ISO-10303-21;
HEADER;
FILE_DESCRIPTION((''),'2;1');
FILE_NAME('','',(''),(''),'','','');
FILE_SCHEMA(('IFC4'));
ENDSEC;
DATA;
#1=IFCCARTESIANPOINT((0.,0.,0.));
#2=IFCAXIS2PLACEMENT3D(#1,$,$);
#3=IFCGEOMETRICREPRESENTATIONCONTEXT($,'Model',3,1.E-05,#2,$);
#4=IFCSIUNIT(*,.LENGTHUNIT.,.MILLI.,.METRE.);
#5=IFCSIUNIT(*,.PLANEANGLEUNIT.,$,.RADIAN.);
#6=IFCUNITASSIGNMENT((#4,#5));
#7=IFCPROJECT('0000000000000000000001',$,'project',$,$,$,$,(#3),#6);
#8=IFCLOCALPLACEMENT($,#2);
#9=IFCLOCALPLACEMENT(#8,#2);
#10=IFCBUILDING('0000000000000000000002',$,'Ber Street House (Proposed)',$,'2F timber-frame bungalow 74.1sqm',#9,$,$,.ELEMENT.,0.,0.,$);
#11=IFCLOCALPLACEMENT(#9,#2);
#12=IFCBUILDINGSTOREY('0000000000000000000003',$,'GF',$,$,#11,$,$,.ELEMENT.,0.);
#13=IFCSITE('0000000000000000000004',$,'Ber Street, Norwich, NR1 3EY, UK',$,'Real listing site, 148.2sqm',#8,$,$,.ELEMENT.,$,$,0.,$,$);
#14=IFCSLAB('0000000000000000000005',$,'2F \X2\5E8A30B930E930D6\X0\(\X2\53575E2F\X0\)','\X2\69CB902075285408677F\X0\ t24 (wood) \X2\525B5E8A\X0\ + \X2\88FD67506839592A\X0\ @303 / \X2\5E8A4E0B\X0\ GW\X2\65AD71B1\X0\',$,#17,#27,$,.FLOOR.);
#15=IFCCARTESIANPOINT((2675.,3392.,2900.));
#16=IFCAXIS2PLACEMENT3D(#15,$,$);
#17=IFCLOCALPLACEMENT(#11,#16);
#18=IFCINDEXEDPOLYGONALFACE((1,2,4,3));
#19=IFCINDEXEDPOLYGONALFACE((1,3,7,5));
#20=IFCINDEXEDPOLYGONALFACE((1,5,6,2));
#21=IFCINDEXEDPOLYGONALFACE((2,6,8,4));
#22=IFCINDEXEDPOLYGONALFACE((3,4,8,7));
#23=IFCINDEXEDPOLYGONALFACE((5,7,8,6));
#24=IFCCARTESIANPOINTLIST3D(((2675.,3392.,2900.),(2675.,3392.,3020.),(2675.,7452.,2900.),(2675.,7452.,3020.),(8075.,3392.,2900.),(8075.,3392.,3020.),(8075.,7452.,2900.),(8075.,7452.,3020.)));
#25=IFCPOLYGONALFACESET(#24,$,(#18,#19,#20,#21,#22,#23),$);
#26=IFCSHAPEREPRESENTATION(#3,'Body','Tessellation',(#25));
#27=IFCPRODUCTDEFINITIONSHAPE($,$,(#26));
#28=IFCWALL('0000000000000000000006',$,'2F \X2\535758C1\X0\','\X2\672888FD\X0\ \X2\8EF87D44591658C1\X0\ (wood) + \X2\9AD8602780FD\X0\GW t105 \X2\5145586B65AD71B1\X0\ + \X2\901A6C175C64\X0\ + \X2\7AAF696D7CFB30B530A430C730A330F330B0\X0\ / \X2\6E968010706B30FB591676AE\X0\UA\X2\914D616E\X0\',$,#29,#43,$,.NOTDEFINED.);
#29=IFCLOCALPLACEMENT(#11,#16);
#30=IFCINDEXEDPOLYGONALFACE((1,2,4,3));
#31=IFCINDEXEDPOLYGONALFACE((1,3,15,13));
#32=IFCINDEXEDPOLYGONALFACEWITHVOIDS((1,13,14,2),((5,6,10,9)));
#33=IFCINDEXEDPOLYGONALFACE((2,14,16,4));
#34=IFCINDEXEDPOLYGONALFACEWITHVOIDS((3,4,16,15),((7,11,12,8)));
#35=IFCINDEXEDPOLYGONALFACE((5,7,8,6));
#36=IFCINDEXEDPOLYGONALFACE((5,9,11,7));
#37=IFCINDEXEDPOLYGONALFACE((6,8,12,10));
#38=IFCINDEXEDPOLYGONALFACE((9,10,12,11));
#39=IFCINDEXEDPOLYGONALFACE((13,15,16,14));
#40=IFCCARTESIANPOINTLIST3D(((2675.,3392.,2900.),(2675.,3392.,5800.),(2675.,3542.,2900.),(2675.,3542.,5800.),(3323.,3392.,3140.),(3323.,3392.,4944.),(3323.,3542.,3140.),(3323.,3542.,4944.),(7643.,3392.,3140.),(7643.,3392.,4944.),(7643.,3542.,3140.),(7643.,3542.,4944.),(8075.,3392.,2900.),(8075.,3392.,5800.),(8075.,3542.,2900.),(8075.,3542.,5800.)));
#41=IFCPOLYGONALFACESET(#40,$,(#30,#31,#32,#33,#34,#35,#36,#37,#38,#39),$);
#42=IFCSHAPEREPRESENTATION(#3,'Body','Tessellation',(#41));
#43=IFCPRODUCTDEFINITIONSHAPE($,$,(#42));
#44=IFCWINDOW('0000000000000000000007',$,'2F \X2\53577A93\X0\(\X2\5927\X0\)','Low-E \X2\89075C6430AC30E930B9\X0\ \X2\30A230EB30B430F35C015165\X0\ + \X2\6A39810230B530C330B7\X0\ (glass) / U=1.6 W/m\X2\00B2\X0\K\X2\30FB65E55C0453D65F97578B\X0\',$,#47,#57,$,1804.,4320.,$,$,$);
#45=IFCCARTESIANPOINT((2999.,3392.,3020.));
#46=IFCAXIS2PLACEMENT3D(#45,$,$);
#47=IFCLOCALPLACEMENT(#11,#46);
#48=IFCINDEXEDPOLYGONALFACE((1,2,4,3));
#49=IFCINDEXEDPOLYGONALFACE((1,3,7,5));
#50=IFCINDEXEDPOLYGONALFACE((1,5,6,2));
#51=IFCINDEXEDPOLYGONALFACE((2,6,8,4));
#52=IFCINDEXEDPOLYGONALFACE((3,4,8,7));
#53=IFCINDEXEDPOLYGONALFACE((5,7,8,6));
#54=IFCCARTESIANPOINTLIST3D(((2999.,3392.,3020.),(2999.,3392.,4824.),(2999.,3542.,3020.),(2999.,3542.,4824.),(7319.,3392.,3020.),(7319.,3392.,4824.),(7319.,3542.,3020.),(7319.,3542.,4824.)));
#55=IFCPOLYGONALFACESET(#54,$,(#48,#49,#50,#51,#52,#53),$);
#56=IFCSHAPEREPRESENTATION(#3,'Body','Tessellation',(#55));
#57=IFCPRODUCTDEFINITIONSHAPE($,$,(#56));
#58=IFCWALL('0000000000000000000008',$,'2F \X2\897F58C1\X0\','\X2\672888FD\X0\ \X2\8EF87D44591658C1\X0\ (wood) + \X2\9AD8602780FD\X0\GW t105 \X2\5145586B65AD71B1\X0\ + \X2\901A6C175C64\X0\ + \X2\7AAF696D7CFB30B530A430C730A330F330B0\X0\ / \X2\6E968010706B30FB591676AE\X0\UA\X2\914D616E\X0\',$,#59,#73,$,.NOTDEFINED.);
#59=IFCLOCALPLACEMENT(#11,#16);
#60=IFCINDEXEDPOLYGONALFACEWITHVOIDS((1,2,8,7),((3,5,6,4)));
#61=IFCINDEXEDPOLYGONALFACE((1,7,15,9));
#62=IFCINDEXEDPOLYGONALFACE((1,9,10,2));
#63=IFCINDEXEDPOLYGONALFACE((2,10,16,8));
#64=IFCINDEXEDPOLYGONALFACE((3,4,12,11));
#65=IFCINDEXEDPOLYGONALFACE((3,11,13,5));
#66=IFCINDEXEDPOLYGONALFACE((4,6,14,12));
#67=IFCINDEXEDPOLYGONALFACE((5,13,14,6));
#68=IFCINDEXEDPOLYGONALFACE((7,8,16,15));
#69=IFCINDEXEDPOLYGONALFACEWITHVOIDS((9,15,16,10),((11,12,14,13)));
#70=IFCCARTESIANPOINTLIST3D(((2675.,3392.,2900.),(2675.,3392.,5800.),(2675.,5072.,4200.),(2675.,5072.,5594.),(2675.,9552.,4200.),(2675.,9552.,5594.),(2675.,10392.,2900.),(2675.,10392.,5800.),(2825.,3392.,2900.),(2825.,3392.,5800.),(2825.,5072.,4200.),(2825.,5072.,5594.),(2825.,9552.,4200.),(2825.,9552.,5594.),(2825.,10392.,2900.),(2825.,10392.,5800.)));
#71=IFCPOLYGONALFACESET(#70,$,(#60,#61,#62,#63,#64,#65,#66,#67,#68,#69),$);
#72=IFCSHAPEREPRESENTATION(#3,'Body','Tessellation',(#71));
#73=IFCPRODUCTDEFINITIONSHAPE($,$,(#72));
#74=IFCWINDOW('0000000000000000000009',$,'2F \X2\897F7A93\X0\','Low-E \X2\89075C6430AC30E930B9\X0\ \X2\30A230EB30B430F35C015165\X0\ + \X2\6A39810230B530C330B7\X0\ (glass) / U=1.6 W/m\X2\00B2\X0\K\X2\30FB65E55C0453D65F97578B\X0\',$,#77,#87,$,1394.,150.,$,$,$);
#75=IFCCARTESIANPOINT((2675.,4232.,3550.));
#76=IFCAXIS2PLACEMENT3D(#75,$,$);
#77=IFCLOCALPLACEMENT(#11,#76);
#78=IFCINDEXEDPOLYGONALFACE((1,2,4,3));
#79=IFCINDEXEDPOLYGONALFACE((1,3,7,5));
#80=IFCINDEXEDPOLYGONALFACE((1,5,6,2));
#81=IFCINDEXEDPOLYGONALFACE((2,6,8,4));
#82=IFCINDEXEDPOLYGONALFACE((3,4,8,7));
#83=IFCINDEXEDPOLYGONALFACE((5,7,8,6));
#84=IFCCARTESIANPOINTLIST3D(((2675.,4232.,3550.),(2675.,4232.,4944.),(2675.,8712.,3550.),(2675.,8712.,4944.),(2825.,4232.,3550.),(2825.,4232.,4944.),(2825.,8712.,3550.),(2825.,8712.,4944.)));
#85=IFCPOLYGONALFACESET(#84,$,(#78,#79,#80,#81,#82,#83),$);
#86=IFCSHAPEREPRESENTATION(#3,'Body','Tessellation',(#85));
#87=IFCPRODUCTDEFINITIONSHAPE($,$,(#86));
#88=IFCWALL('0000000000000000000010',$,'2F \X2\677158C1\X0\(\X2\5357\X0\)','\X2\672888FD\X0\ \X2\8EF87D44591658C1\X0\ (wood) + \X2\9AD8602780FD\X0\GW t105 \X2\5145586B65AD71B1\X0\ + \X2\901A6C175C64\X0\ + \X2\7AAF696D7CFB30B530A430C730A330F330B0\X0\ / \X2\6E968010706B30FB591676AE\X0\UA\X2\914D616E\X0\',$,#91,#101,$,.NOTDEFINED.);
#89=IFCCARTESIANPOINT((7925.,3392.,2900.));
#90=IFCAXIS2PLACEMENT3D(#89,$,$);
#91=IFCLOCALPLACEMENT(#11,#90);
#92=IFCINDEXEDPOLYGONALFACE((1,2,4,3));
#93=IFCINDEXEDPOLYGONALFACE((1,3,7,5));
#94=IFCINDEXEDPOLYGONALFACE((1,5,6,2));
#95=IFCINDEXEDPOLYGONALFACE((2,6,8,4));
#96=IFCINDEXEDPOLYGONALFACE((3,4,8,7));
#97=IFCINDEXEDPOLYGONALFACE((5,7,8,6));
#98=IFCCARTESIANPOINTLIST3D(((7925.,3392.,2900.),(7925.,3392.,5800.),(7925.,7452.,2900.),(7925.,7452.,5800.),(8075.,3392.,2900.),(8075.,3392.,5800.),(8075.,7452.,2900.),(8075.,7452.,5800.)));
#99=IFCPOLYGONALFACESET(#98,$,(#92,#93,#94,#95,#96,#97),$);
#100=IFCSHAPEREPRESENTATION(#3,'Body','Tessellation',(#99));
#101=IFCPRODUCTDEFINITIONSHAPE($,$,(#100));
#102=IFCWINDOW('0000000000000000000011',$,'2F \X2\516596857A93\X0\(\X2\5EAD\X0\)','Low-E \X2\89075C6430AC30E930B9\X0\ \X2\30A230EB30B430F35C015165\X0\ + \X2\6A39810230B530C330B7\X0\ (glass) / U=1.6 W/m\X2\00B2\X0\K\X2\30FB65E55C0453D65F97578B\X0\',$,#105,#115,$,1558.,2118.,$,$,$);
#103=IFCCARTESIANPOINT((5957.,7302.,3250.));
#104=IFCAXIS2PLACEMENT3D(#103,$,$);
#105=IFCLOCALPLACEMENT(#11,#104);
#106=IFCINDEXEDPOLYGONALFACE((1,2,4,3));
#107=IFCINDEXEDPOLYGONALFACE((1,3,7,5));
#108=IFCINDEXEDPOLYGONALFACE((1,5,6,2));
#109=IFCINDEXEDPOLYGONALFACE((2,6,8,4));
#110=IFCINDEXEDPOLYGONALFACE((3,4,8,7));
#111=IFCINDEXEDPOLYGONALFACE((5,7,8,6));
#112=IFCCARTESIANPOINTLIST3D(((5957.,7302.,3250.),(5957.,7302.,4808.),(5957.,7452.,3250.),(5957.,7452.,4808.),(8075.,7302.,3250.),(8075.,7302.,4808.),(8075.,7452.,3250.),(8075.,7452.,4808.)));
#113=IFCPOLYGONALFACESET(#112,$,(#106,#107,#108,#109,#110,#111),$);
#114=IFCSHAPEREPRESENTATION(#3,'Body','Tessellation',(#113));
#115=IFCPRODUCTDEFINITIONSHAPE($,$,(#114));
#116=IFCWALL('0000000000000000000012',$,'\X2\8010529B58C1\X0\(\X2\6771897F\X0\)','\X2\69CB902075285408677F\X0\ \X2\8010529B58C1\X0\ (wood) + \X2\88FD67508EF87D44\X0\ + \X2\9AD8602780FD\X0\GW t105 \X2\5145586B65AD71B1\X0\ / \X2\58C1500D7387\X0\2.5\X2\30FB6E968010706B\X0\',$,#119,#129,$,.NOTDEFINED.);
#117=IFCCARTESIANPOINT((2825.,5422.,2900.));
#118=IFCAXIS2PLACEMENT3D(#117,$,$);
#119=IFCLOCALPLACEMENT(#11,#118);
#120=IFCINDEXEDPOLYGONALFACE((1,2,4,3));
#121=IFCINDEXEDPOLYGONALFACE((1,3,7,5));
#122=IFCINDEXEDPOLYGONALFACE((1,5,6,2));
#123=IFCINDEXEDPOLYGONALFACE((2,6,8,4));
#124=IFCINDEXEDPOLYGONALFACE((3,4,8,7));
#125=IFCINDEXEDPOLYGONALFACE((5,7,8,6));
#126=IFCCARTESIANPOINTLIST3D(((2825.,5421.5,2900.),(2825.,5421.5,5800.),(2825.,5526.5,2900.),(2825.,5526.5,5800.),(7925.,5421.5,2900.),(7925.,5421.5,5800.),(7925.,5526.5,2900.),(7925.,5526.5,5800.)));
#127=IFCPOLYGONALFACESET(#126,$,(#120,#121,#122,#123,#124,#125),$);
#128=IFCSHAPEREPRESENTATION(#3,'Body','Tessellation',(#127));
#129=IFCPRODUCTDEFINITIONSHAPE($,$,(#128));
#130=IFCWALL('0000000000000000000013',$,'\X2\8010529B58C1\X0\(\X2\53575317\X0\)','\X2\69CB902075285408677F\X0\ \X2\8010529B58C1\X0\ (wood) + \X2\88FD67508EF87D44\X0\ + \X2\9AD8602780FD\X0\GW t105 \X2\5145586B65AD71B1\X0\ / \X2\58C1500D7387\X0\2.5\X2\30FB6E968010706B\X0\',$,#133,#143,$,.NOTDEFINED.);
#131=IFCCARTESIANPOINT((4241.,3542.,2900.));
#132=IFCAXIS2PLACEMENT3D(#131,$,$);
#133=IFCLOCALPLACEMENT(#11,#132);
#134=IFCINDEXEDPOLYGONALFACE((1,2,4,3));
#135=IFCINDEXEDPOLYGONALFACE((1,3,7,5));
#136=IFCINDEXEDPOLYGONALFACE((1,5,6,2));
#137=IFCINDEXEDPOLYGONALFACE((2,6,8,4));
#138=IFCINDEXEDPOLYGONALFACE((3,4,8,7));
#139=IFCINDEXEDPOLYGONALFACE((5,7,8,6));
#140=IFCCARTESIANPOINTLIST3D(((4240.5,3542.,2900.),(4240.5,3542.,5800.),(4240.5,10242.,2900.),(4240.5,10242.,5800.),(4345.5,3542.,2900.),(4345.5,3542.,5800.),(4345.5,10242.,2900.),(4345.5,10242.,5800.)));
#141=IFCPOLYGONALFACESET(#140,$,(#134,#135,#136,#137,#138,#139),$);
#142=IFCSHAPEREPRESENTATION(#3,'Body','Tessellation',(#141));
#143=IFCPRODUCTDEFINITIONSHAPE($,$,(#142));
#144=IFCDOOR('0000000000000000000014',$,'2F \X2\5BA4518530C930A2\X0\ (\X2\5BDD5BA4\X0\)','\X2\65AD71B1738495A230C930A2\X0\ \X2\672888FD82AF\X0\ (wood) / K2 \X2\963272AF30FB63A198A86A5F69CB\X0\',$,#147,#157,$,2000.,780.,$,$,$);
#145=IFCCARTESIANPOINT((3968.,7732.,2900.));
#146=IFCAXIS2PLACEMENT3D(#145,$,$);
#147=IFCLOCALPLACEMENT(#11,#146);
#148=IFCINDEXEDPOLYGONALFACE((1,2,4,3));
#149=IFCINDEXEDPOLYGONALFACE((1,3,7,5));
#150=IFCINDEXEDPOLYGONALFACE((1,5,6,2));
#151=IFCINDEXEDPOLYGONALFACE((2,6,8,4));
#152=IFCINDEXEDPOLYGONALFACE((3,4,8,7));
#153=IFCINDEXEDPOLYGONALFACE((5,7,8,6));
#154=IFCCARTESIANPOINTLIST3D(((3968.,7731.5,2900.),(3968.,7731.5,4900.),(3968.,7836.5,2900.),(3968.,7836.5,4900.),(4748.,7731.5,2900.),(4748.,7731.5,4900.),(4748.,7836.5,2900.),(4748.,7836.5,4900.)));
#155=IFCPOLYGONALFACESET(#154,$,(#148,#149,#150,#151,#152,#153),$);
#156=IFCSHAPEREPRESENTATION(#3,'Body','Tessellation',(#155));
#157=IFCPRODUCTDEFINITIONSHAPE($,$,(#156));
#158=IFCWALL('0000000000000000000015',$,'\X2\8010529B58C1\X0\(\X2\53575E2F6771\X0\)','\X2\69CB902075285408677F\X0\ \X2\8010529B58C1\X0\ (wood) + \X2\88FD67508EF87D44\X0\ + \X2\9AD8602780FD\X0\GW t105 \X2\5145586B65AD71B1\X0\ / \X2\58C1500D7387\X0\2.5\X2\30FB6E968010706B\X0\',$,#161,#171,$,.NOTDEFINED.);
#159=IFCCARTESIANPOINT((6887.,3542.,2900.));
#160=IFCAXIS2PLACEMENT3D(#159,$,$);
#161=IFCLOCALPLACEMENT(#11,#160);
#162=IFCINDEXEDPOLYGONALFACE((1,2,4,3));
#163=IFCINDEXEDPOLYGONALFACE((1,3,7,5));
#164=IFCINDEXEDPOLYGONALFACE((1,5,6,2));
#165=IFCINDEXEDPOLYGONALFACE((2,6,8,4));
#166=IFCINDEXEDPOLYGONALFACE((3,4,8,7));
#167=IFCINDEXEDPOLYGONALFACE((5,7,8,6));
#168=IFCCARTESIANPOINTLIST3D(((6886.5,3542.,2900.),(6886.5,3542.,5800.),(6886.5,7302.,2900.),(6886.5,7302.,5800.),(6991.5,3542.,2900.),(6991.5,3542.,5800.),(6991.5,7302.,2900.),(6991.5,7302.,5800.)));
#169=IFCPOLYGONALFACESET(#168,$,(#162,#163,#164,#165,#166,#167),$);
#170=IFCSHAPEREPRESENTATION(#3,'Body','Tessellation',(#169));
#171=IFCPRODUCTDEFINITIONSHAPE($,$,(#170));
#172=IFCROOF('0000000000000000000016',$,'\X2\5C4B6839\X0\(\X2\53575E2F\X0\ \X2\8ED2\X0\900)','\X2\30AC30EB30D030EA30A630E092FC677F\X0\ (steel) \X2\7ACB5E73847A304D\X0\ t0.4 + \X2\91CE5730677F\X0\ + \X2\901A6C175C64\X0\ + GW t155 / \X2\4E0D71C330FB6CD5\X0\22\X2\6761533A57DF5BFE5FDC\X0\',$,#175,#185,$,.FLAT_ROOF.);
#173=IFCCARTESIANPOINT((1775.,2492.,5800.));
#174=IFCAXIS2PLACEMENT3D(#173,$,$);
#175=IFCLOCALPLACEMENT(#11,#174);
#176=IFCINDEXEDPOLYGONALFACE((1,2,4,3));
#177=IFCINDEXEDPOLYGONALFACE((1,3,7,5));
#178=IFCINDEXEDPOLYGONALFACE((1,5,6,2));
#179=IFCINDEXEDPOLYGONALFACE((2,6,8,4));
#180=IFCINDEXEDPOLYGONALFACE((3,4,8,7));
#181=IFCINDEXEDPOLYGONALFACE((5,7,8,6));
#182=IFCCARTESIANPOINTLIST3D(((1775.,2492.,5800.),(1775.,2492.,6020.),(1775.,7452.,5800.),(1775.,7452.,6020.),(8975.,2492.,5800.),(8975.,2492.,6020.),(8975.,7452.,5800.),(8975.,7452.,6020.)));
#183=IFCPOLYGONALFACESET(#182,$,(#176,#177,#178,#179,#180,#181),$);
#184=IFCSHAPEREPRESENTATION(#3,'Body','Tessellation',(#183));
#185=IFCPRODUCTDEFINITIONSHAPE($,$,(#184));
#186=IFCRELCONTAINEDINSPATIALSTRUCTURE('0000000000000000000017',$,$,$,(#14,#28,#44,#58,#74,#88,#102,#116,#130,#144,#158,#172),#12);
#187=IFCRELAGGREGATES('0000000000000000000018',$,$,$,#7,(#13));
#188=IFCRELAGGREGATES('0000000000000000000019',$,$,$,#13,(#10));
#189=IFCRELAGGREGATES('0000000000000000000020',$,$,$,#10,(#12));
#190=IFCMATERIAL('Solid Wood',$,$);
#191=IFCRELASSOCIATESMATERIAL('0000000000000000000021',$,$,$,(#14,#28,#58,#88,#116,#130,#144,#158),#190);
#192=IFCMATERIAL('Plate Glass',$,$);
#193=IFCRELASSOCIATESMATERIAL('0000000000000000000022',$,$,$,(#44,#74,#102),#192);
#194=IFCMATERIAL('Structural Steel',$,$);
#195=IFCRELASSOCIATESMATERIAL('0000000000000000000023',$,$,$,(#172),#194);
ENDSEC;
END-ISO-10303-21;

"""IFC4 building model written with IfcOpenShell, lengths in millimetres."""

from ifc_helpers import new_model, si_unit, frame, frame_2d, origin, place, context, project, spatial, rectangle, extrude, material, element, fill, save


model = new_model("IFC4")

# Units and contexts
model_context = context("Model", 3, precision=1e-05, world=origin())
ifc_project = project(units=[si_unit("LENGTHUNIT", "METRE", prefix="MILLI"), si_unit("PLANEANGLEUNIT", "RADIAN")], contexts=[model_context])

# Site, building, storey
site_placement = place(None, origin())
site = spatial("IfcSite", under=ifc_project, at=site_placement, Name="Ber Street, Norwich, NR1 3EY, UK", ObjectType="Real listing site, 148.2sqm", CompositionType="ELEMENT", RefElevation=0.0)
building_placement = place(site_placement, origin())
building = spatial("IfcBuilding", under=site, at=building_placement, Name="Ber Street House (Proposed)", ObjectType="2F timber-frame bungalow 74.1sqm", CompositionType="ELEMENT", ElevationOfRefHeight=0.0, ElevationOfTerrain=0.0)
storey_placement = place(building_placement, origin())
storey = spatial("IfcBuildingStorey", under=building, at=storey_placement, Name="GF", CompositionType="ELEMENT", Elevation=0.0)

# Slab
ifc_material_1 = material(Name="Solid Wood")
slab_placement = place(storey_placement, frame((2675.0, 3392.0, 2900.0)))
element("IfcSlab", 1, at=slab_placement, inside=storey, material=ifc_material_1, Name="2F 床スラブ(南帯)", Description="構造用合板 t24 (wood) 剛床 + 製材根太 @303 / 床下 GW断熱", PredefinedType="FLOOR", context=model_context, shape_type="SweptSolid", body=[
    extrude(rectangle(XDim=5400.0, YDim=4060.0, at=frame_2d((2700.0, 2030.0))), frame((2675.0, 3392.0, 2900.0)), (0.0, 0.0, 1.0), 120.0),
])

# Walls, openings, windows
wall_1_placement = place(storey_placement, frame((2675.0, 3392.0, 2900.0)))
wall_1 = element("IfcWall", 2, at=wall_1_placement, inside=storey, material=ifc_material_1, Name="2F 南壁", Description="木製 軸組外壁 (wood) + 高性能GW t105 充填断熱 + 通気層 + 窯業系サイディング / 準耐火・外皮UA配慮", PredefinedType="NOTDEFINED", context=model_context, shape_type="SweptSolid", body=[
    extrude(rectangle(XDim=5400.0, YDim=150.0, at=frame_2d((2700.0, 75.0))), frame((2675.0, 3392.0, 2900.0)), (0.0, 0.0, 1.0), 2900.0),
])
opening_1_placement = place(storey_placement, frame((2999.0, 3392.0, 3020.0)))
opening_1 = element("IfcOpeningElement", 3, at=opening_1_placement, cuts=wall_1, PredefinedType="NOTDEFINED", context=model_context, shape_type="SweptSolid", body=[
    extrude(rectangle(XDim=4320.0, YDim=150.0, at=frame_2d((2160.0, 75.0))), frame((2999.0, 3392.0, 3020.0)), (0.0, 0.0, 1.0), 1804.0),
])
ifc_material_2 = material(Name="Plate Glass")
window_1_placement = place(storey_placement, frame((2999.0, 3392.0, 3020.0)))
window_1 = element("IfcWindow", 4, at=window_1_placement, inside=storey, material=ifc_material_2, Name="2F 南窓(大)", Description="Low-E 複層ガラス アルゴン封入 + 樹脂サッシ (glass) / U=1.6 W/m²K・日射取得型", OverallHeight=1804.0, OverallWidth=4320.0, context=model_context, shape_type="SweptSolid", body=[
    extrude(rectangle(XDim=4320.0, YDim=150.0, at=frame_2d((2160.0, 75.0))), frame((2999.0, 3392.0, 3020.0)), (0.0, 0.0, 1.0), 1804.0),
])
fill(opening_1, window_1)
wall_2_placement = place(storey_placement, frame((2675.0, 3392.0, 2900.0)))
wall_2 = element("IfcWall", 5, at=wall_2_placement, inside=storey, material=ifc_material_1, Name="2F 西壁", Description="木製 軸組外壁 (wood) + 高性能GW t105 充填断熱 + 通気層 + 窯業系サイディング / 準耐火・外皮UA配慮", PredefinedType="NOTDEFINED", context=model_context, shape_type="SweptSolid", body=[
    extrude(rectangle(XDim=150.0, YDim=7000.0, at=frame_2d((75.0, 3500.0))), frame((2675.0, 3392.0, 2900.0)), (0.0, 0.0, 1.0), 2900.0),
])
opening_2_placement = place(storey_placement, frame((2675.0, 4232.0, 3550.0)))
opening_2 = element("IfcOpeningElement", 6, at=opening_2_placement, cuts=wall_2, PredefinedType="NOTDEFINED", context=model_context, shape_type="SweptSolid", body=[
    extrude(rectangle(XDim=150.0, YDim=4480.0, at=frame_2d((75.0, 2240.0))), frame((2675.0, 4232.0, 3550.0)), (0.0, 0.0, 1.0), 1394.0),
])
window_2_placement = place(storey_placement, frame((2675.0, 4232.0, 3550.0)))
window_2 = element("IfcWindow", 7, at=window_2_placement, inside=storey, material=ifc_material_2, Name="2F 西窓", Description="Low-E 複層ガラス アルゴン封入 + 樹脂サッシ (glass) / U=1.6 W/m²K・日射取得型", OverallHeight=1394.0, OverallWidth=150.0, context=model_context, shape_type="SweptSolid", body=[
    extrude(rectangle(XDim=150.0, YDim=4480.0, at=frame_2d((75.0, 2240.0))), frame((2675.0, 4232.0, 3550.0)), (0.0, 0.0, 1.0), 1394.0),
])
fill(opening_2, window_2)
wall_3_placement = place(storey_placement, frame((7925.0, 3392.0, 2900.0)))
wall_3 = element("IfcWall", 8, at=wall_3_placement, inside=storey, material=ifc_material_1, Name="2F 東壁(南)", Description="木製 軸組外壁 (wood) + 高性能GW t105 充填断熱 + 通気層 + 窯業系サイディング / 準耐火・外皮UA配慮", PredefinedType="NOTDEFINED", context=model_context, shape_type="SweptSolid", body=[
    extrude(rectangle(XDim=150.0, YDim=4060.0, at=frame_2d((75.0, 2030.0))), frame((7925.0, 3392.0, 2900.0)), (0.0, 0.0, 1.0), 2900.0),
])
opening_3_placement = place(storey_placement, frame((5957.0, 7302.0, 3250.0)))
opening_3 = element("IfcOpeningElement", 9, at=opening_3_placement, cuts=wall_3, PredefinedType="NOTDEFINED", context=model_context, shape_type="SweptSolid", body=[
    extrude(rectangle(XDim=2118.0, YDim=150.0, at=frame_2d((1059.0, 75.0))), frame((5957.0, 7302.0, 3250.0)), (0.0, 0.0, 1.0), 1558.0),
])
window_3_placement = place(storey_placement, frame((5957.0, 7302.0, 3250.0)))
window_3 = element("IfcWindow", 10, at=window_3_placement, inside=storey, material=ifc_material_2, Name="2F 入隅窓(庭)", Description="Low-E 複層ガラス アルゴン封入 + 樹脂サッシ (glass) / U=1.6 W/m²K・日射取得型", OverallHeight=1558.0, OverallWidth=2118.0, context=model_context, shape_type="SweptSolid", body=[
    extrude(rectangle(XDim=2118.0, YDim=150.0, at=frame_2d((1059.0, 75.0))), frame((5957.0, 7302.0, 3250.0)), (0.0, 0.0, 1.0), 1558.0),
])
fill(opening_3, window_3)

# Wall
wall_4_placement = place(storey_placement, frame((2825.0, 5422.0, 2900.0)))
element("IfcWall", 11, at=wall_4_placement, inside=storey, material=ifc_material_1, Name="耐力壁(東西)", Description="構造用合板 耐力壁 (wood) + 製材軸組 + 高性能GW t105 充填断熱 / 壁倍率2.5・準耐火", PredefinedType="NOTDEFINED", context=model_context, shape_type="SweptSolid", body=[
    extrude(rectangle(XDim=5100.0, YDim=105.0, at=frame_2d((2550.0, 52.0))), frame((2825.0, 5422.0, 2900.0)), (0.0, 0.0, 1.0), 2900.0),
])

# Wall, opening, door
wall_5_placement = place(storey_placement, frame((4241.0, 3542.0, 2900.0)))
wall_5 = element("IfcWall", 12, at=wall_5_placement, inside=storey, material=ifc_material_1, Name="耐力壁(南北)", Description="構造用合板 耐力壁 (wood) + 製材軸組 + 高性能GW t105 充填断熱 / 壁倍率2.5・準耐火", PredefinedType="NOTDEFINED", context=model_context, shape_type="SweptSolid", body=[
    extrude(rectangle(XDim=105.0, YDim=6700.0, at=frame_2d((52.0, 3350.0))), frame((4241.0, 3542.0, 2900.0)), (0.0, 0.0, 1.0), 2900.0),
])
opening_4_placement = place(storey_placement, frame((3968.0, 7732.0, 2900.0)))
opening_4 = element("IfcOpeningElement", 13, at=opening_4_placement, cuts=wall_5, PredefinedType="NOTDEFINED", context=model_context, shape_type="SweptSolid", body=[
    extrude(rectangle(XDim=780.0, YDim=105.0, at=frame_2d((390.0, 52.0))), frame((3968.0, 7732.0, 2900.0)), (0.0, 0.0, 1.0), 2000.0),
])
door_placement = place(storey_placement, frame((3968.0, 7732.0, 2900.0)))
door = element("IfcDoor", 14, at=door_placement, inside=storey, material=ifc_material_1, Name="2F 室内ドア (寝室)", Description="断熱玄関ドア 木製芯 (wood) / K2 防犯・採風機構", OverallHeight=2000.0, OverallWidth=780.0, context=model_context, shape_type="SweptSolid", body=[
    extrude(rectangle(XDim=780.0, YDim=105.0, at=frame_2d((390.0, 52.0))), frame((3968.0, 7732.0, 2900.0)), (0.0, 0.0, 1.0), 2000.0),
])
fill(opening_4, door)

# Wall
wall_6_placement = place(storey_placement, frame((6887.0, 3542.0, 2900.0)))
element("IfcWall", 15, at=wall_6_placement, inside=storey, material=ifc_material_1, Name="耐力壁(南帯東)", Description="構造用合板 耐力壁 (wood) + 製材軸組 + 高性能GW t105 充填断熱 / 壁倍率2.5・準耐火", PredefinedType="NOTDEFINED", context=model_context, shape_type="SweptSolid", body=[
    extrude(rectangle(XDim=105.0, YDim=3760.0, at=frame_2d((52.0, 1880.0))), frame((6887.0, 3542.0, 2900.0)), (0.0, 0.0, 1.0), 2900.0),
])

# Roof
ifc_material_3 = material(Name="Structural Steel")
for number, where, name in (
    (16, (1775.0, 2492.0, 5800.0), "屋根(南帯 軒900)"),
):
    element("IfcRoof", number, at=place(storey_placement, frame(where)), inside=storey, material=ifc_material_3, Name=name, Description="ガルバリウム鋼板 (steel) 立平葺き t0.4 + 野地板 + 通気層 + GW t155 / 不燃・法22条区域対応", PredefinedType="FLAT_ROOF", context=model_context, shape_type="SweptSolid", body=[
        extrude(rectangle(XDim=7200.0, YDim=4960.0, at=frame_2d((3600.0, 2480.0))), frame((1775.0, 2492.0, 5800.0)), (0.0, 0.0, 1.0), 220.0),
    ])

save(model, "model.ifc")
